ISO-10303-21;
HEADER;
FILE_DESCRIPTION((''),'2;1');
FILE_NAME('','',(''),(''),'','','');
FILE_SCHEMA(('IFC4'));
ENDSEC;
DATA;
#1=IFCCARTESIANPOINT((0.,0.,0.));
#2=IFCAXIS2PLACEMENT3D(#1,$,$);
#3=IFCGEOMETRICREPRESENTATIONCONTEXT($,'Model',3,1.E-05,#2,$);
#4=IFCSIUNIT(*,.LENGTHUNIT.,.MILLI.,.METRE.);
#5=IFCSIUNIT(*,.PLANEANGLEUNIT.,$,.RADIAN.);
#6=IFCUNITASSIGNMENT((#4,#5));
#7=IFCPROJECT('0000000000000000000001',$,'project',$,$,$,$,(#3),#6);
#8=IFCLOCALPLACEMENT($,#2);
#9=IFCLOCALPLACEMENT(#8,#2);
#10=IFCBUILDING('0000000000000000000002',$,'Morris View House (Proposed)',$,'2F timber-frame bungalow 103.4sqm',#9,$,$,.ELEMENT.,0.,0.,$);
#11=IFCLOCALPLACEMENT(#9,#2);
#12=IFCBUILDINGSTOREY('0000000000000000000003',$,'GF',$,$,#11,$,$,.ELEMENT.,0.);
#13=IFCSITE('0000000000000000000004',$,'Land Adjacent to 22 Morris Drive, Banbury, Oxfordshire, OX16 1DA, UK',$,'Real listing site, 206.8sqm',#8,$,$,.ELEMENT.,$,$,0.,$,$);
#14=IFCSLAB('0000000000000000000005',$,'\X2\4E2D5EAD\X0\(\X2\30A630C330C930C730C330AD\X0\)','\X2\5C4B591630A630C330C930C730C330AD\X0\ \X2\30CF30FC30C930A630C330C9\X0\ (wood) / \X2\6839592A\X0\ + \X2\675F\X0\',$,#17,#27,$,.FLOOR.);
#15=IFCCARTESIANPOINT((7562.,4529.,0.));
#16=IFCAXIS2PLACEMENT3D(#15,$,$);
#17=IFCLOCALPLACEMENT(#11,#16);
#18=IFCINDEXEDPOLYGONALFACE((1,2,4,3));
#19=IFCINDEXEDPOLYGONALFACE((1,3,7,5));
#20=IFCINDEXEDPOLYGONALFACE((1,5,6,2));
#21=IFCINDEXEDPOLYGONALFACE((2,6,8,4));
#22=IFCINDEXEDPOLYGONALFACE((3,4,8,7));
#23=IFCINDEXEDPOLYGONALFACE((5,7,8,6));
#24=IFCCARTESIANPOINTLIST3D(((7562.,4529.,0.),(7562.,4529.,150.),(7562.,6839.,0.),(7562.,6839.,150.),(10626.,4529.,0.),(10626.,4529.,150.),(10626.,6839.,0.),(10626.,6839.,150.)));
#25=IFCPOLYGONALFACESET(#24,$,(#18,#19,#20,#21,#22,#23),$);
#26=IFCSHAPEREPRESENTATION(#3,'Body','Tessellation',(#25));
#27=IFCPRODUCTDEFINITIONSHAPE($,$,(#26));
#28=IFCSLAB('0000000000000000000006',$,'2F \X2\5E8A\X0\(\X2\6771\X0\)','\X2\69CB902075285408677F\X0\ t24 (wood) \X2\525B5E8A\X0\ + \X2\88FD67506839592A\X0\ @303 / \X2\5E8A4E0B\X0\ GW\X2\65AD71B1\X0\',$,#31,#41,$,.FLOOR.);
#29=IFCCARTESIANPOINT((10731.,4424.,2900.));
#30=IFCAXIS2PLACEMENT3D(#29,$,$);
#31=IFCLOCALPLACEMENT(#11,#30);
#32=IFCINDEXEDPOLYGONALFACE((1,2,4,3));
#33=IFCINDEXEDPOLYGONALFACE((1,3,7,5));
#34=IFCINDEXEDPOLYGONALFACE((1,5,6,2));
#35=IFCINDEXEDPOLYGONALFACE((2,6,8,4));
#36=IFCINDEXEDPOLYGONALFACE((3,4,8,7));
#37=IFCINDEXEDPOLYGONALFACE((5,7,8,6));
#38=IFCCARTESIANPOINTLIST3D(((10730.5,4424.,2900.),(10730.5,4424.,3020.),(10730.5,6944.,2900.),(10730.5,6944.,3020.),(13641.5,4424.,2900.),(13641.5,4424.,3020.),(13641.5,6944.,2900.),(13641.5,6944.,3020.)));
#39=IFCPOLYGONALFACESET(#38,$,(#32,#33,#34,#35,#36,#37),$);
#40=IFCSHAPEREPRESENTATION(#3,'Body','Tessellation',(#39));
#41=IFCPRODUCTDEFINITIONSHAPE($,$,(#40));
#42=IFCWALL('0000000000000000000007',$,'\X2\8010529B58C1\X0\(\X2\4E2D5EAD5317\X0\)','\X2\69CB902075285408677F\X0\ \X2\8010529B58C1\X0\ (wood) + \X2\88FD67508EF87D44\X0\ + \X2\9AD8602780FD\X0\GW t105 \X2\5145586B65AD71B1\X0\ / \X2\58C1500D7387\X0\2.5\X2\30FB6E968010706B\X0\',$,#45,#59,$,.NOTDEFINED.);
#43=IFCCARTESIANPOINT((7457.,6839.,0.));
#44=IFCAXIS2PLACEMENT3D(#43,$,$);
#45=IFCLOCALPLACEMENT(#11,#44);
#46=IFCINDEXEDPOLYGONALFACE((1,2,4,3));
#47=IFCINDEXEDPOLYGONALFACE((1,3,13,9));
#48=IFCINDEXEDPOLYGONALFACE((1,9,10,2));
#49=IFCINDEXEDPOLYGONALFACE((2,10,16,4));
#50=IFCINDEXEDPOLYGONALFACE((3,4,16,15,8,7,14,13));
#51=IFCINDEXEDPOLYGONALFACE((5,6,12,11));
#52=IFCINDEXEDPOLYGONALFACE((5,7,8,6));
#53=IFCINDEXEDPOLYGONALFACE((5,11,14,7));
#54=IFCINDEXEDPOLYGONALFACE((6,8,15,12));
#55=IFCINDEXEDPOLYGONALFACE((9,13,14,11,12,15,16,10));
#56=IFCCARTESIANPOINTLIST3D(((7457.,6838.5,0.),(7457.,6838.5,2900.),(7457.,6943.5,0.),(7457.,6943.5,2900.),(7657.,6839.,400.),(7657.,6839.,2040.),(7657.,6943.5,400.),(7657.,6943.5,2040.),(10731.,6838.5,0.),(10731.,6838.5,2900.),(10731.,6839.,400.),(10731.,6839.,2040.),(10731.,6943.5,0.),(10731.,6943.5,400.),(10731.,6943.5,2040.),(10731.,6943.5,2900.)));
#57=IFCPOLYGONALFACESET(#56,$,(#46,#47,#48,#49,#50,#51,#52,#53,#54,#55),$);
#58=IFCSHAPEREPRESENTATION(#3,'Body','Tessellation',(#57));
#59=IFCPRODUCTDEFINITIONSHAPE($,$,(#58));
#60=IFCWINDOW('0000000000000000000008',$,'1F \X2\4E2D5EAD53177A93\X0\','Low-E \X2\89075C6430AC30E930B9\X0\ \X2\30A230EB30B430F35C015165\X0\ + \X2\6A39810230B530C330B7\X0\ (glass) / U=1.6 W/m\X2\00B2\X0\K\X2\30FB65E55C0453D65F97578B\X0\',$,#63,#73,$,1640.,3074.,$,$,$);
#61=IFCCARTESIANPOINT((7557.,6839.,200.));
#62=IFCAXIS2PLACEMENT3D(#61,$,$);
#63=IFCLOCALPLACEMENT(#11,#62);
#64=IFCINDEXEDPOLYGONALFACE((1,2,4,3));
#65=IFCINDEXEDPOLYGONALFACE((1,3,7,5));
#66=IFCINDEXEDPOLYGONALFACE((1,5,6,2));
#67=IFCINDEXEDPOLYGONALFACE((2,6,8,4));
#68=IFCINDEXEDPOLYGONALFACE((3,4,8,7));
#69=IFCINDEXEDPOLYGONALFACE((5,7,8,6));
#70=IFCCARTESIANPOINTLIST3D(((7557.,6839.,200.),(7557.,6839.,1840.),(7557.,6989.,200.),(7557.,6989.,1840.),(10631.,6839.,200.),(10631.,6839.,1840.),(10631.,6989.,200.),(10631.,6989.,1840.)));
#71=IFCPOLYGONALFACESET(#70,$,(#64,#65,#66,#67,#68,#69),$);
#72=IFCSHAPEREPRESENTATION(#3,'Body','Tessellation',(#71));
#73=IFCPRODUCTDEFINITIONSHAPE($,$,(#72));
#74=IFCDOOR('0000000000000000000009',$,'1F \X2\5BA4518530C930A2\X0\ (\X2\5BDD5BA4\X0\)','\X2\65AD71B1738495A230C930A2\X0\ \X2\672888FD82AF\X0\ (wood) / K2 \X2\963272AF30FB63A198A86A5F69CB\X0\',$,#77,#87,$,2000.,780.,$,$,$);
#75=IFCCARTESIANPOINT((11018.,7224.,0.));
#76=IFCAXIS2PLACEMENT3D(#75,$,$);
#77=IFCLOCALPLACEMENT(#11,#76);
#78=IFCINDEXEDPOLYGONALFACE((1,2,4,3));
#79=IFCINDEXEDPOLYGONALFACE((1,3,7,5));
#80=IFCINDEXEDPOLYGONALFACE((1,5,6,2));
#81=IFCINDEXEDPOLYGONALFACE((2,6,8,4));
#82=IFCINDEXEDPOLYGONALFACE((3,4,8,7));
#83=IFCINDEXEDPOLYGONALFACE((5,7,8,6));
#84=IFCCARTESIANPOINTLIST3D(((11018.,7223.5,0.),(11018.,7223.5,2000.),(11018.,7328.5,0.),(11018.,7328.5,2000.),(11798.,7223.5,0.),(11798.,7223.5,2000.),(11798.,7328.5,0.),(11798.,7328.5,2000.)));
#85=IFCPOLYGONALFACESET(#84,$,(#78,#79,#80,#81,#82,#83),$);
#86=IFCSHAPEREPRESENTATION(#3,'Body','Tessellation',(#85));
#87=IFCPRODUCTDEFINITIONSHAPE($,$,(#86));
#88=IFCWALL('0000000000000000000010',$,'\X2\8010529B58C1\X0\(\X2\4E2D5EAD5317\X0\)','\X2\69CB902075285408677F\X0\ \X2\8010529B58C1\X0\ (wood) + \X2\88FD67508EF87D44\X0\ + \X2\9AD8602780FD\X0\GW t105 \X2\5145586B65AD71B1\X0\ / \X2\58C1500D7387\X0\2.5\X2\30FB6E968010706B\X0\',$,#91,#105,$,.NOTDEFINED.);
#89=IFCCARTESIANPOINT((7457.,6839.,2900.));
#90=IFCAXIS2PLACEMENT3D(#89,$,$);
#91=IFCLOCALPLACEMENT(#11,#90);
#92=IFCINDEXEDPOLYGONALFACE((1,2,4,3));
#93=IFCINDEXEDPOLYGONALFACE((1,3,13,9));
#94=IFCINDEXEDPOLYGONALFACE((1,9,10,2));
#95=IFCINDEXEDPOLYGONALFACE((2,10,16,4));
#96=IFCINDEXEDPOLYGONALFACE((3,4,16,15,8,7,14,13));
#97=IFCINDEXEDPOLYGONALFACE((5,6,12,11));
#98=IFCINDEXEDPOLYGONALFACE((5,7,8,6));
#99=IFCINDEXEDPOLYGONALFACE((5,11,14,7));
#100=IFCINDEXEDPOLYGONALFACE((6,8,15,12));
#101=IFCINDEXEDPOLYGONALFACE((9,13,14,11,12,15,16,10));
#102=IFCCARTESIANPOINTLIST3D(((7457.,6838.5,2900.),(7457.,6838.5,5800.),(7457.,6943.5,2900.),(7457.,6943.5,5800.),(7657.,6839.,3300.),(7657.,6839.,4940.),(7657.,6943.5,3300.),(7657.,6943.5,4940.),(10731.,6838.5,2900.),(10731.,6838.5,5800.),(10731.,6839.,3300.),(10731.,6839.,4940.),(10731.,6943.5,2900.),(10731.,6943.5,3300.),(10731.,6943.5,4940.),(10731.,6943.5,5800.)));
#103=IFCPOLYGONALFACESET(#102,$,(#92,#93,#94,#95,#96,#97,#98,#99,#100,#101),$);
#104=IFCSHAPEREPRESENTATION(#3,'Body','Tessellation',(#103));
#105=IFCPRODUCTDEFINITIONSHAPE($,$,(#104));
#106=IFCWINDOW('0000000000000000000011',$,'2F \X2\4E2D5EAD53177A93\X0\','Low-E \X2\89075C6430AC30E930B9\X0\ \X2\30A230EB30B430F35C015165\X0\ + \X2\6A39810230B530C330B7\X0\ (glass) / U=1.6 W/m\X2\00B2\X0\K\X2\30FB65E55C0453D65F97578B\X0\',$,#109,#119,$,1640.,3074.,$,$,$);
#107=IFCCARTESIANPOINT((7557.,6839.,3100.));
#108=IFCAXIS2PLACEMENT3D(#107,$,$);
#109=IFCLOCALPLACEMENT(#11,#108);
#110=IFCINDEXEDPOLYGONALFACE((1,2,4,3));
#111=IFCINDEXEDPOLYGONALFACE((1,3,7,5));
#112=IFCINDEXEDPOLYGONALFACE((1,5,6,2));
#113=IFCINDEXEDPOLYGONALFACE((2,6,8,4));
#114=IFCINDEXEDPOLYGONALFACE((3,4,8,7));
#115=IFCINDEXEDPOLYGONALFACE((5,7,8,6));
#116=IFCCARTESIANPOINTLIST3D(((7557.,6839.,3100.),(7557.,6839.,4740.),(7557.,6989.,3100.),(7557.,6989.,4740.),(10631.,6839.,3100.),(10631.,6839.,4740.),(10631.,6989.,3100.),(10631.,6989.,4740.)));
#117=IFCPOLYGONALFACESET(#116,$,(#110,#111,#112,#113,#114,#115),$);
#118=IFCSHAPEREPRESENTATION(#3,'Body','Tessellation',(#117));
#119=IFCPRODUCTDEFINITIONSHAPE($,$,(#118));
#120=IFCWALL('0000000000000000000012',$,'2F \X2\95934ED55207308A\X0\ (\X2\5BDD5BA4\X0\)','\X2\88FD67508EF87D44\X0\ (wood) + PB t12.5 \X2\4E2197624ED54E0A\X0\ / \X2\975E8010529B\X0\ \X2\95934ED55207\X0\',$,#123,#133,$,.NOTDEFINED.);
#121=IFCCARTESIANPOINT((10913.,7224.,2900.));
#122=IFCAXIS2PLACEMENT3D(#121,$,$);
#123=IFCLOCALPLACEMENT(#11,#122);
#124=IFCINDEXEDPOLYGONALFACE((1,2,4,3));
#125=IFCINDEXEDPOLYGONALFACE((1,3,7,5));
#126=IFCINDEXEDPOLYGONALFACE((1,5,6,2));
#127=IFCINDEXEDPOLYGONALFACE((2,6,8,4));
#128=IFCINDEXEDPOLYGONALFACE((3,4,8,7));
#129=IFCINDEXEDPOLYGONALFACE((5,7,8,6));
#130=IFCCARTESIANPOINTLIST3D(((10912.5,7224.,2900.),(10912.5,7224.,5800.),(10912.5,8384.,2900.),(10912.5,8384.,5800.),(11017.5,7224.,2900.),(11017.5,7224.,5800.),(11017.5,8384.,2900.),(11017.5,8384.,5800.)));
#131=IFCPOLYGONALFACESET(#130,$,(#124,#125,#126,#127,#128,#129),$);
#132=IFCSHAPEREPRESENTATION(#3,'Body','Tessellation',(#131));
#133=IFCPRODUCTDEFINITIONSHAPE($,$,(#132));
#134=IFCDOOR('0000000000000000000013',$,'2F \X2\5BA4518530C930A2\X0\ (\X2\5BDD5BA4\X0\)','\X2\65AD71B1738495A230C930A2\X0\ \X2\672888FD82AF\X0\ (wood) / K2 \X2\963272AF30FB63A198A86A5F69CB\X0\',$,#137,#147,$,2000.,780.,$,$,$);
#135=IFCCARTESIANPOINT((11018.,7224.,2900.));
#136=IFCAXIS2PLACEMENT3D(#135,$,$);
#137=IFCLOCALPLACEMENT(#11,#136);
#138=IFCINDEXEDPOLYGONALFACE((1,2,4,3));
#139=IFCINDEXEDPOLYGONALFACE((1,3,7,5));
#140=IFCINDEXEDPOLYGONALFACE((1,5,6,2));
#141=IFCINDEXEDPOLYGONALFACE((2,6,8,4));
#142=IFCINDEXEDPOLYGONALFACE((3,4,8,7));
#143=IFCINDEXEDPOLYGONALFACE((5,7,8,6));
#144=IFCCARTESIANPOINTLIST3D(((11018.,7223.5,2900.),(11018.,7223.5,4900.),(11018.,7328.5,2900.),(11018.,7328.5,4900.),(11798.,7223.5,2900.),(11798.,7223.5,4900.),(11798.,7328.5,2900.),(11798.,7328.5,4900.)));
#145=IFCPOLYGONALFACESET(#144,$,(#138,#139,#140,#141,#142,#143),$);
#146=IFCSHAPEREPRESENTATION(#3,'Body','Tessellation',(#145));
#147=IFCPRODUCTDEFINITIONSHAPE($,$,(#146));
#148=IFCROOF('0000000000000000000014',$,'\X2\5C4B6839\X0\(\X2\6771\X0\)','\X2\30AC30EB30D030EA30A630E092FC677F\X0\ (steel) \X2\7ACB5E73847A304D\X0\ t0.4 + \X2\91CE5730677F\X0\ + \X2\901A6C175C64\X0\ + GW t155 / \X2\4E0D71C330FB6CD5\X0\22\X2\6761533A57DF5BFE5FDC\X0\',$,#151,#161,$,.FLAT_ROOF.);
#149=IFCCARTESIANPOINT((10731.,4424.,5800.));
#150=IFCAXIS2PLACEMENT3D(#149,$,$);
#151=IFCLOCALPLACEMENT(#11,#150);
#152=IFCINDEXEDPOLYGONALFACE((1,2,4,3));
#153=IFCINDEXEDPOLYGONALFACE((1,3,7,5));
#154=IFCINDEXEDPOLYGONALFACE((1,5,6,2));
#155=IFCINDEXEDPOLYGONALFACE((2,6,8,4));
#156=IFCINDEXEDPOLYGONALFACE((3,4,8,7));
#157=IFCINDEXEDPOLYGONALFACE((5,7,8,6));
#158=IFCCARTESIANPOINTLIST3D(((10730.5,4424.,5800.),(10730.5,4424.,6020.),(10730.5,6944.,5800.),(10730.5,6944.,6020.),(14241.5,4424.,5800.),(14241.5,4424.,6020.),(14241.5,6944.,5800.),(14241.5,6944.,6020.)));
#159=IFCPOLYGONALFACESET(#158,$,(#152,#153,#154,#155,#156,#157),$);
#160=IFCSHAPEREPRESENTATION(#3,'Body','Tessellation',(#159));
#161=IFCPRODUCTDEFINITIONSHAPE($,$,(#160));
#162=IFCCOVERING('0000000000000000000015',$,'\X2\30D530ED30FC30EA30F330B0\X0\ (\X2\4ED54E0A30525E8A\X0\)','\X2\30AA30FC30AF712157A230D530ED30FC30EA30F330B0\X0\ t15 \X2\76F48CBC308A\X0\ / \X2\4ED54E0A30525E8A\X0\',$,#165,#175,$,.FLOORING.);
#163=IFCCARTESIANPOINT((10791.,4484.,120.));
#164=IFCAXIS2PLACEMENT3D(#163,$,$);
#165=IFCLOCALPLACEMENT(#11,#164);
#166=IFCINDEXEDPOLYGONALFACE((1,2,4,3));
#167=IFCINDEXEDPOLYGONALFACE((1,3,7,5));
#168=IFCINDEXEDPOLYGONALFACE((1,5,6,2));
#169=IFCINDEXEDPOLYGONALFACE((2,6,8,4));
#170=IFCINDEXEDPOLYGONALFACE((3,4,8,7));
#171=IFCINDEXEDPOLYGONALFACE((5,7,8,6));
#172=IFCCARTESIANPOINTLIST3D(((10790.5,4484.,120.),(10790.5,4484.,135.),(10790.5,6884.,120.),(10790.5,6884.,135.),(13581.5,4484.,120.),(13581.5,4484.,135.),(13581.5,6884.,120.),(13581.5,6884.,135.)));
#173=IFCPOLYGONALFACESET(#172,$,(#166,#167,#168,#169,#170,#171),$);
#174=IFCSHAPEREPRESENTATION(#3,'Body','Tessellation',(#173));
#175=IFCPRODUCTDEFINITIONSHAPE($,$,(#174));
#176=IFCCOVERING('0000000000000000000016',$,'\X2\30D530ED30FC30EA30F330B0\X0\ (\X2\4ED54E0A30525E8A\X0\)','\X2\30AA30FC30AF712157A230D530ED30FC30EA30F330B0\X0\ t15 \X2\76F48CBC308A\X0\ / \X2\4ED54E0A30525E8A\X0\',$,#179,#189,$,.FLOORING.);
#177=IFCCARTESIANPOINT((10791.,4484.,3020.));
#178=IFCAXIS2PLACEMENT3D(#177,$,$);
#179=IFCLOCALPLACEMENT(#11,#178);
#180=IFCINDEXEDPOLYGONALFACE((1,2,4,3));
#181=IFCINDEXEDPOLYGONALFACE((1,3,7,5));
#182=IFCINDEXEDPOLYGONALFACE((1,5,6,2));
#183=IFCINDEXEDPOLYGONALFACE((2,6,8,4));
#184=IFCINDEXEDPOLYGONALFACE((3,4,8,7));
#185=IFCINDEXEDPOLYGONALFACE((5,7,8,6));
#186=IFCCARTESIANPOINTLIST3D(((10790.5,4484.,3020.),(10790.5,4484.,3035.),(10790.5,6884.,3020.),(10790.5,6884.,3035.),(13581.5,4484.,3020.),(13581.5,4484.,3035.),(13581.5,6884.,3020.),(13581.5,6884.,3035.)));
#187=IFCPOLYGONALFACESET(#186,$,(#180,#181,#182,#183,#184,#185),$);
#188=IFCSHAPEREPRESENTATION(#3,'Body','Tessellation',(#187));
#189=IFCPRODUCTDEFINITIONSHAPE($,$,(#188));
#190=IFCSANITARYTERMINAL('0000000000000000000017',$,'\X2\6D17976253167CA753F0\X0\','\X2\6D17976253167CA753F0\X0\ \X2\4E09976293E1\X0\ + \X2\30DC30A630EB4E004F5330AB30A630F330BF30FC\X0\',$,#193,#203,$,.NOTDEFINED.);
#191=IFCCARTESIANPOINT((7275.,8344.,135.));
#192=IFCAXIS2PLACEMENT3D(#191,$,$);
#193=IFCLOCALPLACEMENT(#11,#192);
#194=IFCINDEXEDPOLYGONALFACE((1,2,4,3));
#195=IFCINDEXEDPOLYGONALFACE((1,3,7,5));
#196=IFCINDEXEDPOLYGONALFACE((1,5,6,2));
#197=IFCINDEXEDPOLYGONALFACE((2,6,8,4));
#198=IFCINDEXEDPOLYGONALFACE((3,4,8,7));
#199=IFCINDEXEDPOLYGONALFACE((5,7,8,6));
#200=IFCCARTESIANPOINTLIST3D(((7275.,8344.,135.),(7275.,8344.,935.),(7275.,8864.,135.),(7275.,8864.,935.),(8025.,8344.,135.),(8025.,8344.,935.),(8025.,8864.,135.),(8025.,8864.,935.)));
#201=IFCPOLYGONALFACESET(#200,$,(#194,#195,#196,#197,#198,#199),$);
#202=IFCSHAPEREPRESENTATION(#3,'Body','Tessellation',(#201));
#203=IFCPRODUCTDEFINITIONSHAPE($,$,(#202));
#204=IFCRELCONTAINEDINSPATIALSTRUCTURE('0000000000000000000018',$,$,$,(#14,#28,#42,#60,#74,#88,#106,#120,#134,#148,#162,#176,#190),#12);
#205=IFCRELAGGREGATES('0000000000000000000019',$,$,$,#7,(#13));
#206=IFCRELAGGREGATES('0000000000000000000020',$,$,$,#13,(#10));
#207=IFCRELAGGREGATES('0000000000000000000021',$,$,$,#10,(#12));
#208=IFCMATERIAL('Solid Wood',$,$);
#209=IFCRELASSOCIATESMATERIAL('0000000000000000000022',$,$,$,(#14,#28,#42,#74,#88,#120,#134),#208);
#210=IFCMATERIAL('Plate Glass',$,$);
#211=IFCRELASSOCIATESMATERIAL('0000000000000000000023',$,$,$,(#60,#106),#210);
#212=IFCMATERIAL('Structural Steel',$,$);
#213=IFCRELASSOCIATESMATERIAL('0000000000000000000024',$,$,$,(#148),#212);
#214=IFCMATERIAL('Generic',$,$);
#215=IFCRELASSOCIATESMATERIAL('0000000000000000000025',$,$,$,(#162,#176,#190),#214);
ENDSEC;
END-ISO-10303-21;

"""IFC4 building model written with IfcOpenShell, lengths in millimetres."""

from ifc_helpers import new_model, si_unit, frame, frame_2d, origin, place, context, project, spatial, rectangle, extrude, material, element, fill, save


model = new_model("IFC4")

# Units and contexts
model_context = context("Model", 3, precision=1e-05, world=origin())
ifc_project = project(units=[si_unit("LENGTHUNIT", "METRE", prefix="MILLI"), si_unit("PLANEANGLEUNIT", "RADIAN")], contexts=[model_context])

# Site, building, storey
site_placement = place(None, origin())
site = spatial("IfcSite", under=ifc_project, at=site_placement, Name="Land Adjacent to 22 Morris Drive, Banbury, Oxfordshire, OX16 1DA, UK", ObjectType="Real listing site, 206.8sqm", CompositionType="ELEMENT", RefElevation=0.0)
building_placement = place(site_placement, origin())
building = spatial("IfcBuilding", under=site, at=building_placement, Name="Morris View House (Proposed)", ObjectType="2F timber-frame bungalow 103.4sqm", CompositionType="ELEMENT", ElevationOfRefHeight=0.0, ElevationOfTerrain=0.0)
storey_placement = place(building_placement, origin())
storey = spatial("IfcBuildingStorey", under=building, at=storey_placement, Name="GF", CompositionType="ELEMENT", Elevation=0.0)

# Slabs
ifc_material_1 = material(Name="Solid Wood")
slab_1_placement = place(storey_placement, frame((7562.0, 4529.0, 0.0)))
element("IfcSlab", 1, at=slab_1_placement, inside=storey, material=ifc_material_1, Name="中庭(ウッドデッキ)", Description="屋外ウッドデッキ ハードウッド (wood) / 根太 + 束", PredefinedType="FLOOR", context=model_context, shape_type="SweptSolid", body=[
    extrude(rectangle(XDim=3064.0, YDim=2310.0, at=frame_2d((1532.0, 1155.0))), frame((7562.0, 4529.0, 0.0)), (0.0, 0.0, 1.0), 150.0),
])
slab_2_placement = place(storey_placement, frame((10731.0, 4424.0, 2900.0)))
element("IfcSlab", 2, at=slab_2_placement, inside=storey, material=ifc_material_1, Name="2F 床(東)", Description="構造用合板 t24 (wood) 剛床 + 製材根太 @303 / 床下 GW断熱", PredefinedType="FLOOR", context=model_context, shape_type="SweptSolid", body=[
    extrude(rectangle(XDim=2911.0, YDim=2520.0, at=frame_2d((1455.0, 1260.0))), frame((10731.0, 4424.0, 2900.0)), (0.0, 0.0, 1.0), 120.0),
])

# Wall, opening, window
wall_1_placement = place(storey_placement, frame((7457.0, 6839.0, 0.0)))
wall_1 = element("IfcWall", 3, at=wall_1_placement, inside=storey, material=ifc_material_1, Name="耐力壁(中庭北)", Description="構造用合板 耐力壁 (wood) + 製材軸組 + 高性能GW t105 充填断熱 / 壁倍率2.5・準耐火", PredefinedType="NOTDEFINED", context=model_context, shape_type="SweptSolid", body=[
    extrude(rectangle(XDim=3274.0, YDim=105.0, at=frame_2d((1637.0, 52.0))), frame((7457.0, 6839.0, 0.0)), (0.0, 0.0, 1.0), 2900.0),
])
opening_1_placement = place(storey_placement, frame((7557.0, 6839.0, 200.0)))
opening_1 = element("IfcOpeningElement", 4, at=opening_1_placement, cuts=wall_1, PredefinedType="NOTDEFINED", context=model_context, shape_type="SweptSolid", body=[
    extrude(rectangle(XDim=3074.0, YDim=150.0, at=frame_2d((1537.0, 75.0))), frame((7557.0, 6839.0, 200.0)), (0.0, 0.0, 1.0), 1640.0),
])
ifc_material_2 = material(Name="Plate Glass")
window_1_placement = place(storey_placement, frame((7557.0, 6839.0, 200.0)))
window_1 = element("IfcWindow", 5, at=window_1_placement, inside=storey, material=ifc_material_2, Name="1F 中庭北窓", Description="Low-E 複層ガラス アルゴン封入 + 樹脂サッシ (glass) / U=1.6 W/m²K・日射取得型", OverallHeight=1640.0, OverallWidth=3074.0, context=model_context, shape_type="SweptSolid", body=[
    extrude(rectangle(XDim=3074.0, YDim=150.0, at=frame_2d((1537.0, 75.0))), frame((7557.0, 6839.0, 200.0)), (0.0, 0.0, 1.0), 1640.0),
])
fill(opening_1, window_1)

# Door
door_1_placement = place(storey_placement, frame((11018.0, 7224.0, 0.0)))
element("IfcDoor", 6, at=door_1_placement, inside=storey, material=ifc_material_1, Name="1F 室内ドア (寝室)", Description="断熱玄関ドア 木製芯 (wood) / K2 防犯・採風機構", OverallHeight=2000.0, OverallWidth=780.0, context=model_context, shape_type="SweptSolid", body=[
    extrude(rectangle(XDim=780.0, YDim=105.0, at=frame_2d((390.0, 52.0))), frame((11018.0, 7224.0, 0.0)), (0.0, 0.0, 1.0), 2000.0),
])

# Wall, opening, window
wall_2_placement = place(storey_placement, frame((7457.0, 6839.0, 2900.0)))
wall_2 = element("IfcWall", 7, at=wall_2_placement, inside=storey, material=ifc_material_1, Name="耐力壁(中庭北)", Description="構造用合板 耐力壁 (wood) + 製材軸組 + 高性能GW t105 充填断熱 / 壁倍率2.5・準耐火", PredefinedType="NOTDEFINED", context=model_context, shape_type="SweptSolid", body=[
    extrude(rectangle(XDim=3274.0, YDim=105.0, at=frame_2d((1637.0, 52.0))), frame((7457.0, 6839.0, 2900.0)), (0.0, 0.0, 1.0), 2900.0),
])
opening_2_placement = place(storey_placement, frame((7557.0, 6839.0, 3100.0)))
opening_2 = element("IfcOpeningElement", 8, at=opening_2_placement, cuts=wall_2, PredefinedType="NOTDEFINED", context=model_context, shape_type="SweptSolid", body=[
    extrude(rectangle(XDim=3074.0, YDim=150.0, at=frame_2d((1537.0, 75.0))), frame((7557.0, 6839.0, 3100.0)), (0.0, 0.0, 1.0), 1640.0),
])
window_2_placement = place(storey_placement, frame((7557.0, 6839.0, 3100.0)))
window_2 = element("IfcWindow", 9, at=window_2_placement, inside=storey, material=ifc_material_2, Name="2F 中庭北窓", Description="Low-E 複層ガラス アルゴン封入 + 樹脂サッシ (glass) / U=1.6 W/m²K・日射取得型", OverallHeight=1640.0, OverallWidth=3074.0, context=model_context, shape_type="SweptSolid", body=[
    extrude(rectangle(XDim=3074.0, YDim=150.0, at=frame_2d((1537.0, 75.0))), frame((7557.0, 6839.0, 3100.0)), (0.0, 0.0, 1.0), 1640.0),
])
fill(opening_2, window_2)

# Wall
wall_3_placement = place(storey_placement, frame((10913.0, 7224.0, 2900.0)))
element("IfcWall", 10, at=wall_3_placement, inside=storey, material=ifc_material_1, Name="2F 間仕切り (寝室)", Description="製材軸組 (wood) + PB t12.5 両面仕上 / 非耐力 間仕切", PredefinedType="NOTDEFINED", context=model_context, shape_type="SweptSolid", body=[
    extrude(rectangle(XDim=105.0, YDim=1160.0, at=frame_2d((52.0, 580.0))), frame((10913.0, 7224.0, 2900.0)), (0.0, 0.0, 1.0), 2900.0),
])

# Door
door_2_placement = place(storey_placement, frame((11018.0, 7224.0, 2900.0)))
element("IfcDoor", 11, at=door_2_placement, inside=storey, material=ifc_material_1, Name="2F 室内ドア (寝室)", Description="断熱玄関ドア 木製芯 (wood) / K2 防犯・採風機構", OverallHeight=2000.0, OverallWidth=780.0, context=model_context, shape_type="SweptSolid", body=[
    extrude(rectangle(XDim=780.0, YDim=105.0, at=frame_2d((390.0, 52.0))), frame((11018.0, 7224.0, 2900.0)), (0.0, 0.0, 1.0), 2000.0),
])

# Roof
ifc_material_3 = material(Name="Structural Steel")
for number, where, name in (
    (12, (10731.0, 4424.0, 5800.0), "屋根(東)"),
):
    element("IfcRoof", number, at=place(storey_placement, frame(where)), inside=storey, material=ifc_material_3, Name=name, Description="ガルバリウム鋼板 (steel) 立平葺き t0.4 + 野地板 + 通気層 + GW t155 / 不燃・法22条区域対応", PredefinedType="FLAT_ROOF", context=model_context, shape_type="SweptSolid", body=[
        extrude(rectangle(XDim=3511.0, YDim=2520.0, at=frame_2d((1755.0, 1260.0))), frame((10731.0, 4424.0, 5800.0)), (0.0, 0.0, 1.0), 220.0),
    ])

# Coverings
ifc_material_4 = material(Name="Generic")
covering_1_placement = place(storey_placement, frame((10791.0, 4484.0, 120.0)))
element("IfcCovering", 13, at=covering_1_placement, inside=storey, material=ifc_material_4, Name="フローリング (仕上げ床)", Description="オーク無垢フローリング t15 直貼り / 仕上げ床", PredefinedType="FLOORING", context=model_context, shape_type="SweptSolid", body=[
    extrude(rectangle(XDim=2791.0, YDim=2400.0, at=frame_2d((1395.0, 1200.0))), frame((10791.0, 4484.0, 120.0)), (0.0, 0.0, 1.0), 15.0),
])
covering_2_placement = place(storey_placement, frame((10791.0, 4484.0, 3020.0)))
element("IfcCovering", 14, at=covering_2_placement, inside=storey, material=ifc_material_4, Name="フローリング (仕上げ床)", Description="オーク無垢フローリング t15 直貼り / 仕上げ床", PredefinedType="FLOORING", context=model_context, shape_type="SweptSolid", body=[
    extrude(rectangle(XDim=2791.0, YDim=2400.0, at=frame_2d((1395.0, 1200.0))), frame((10791.0, 4484.0, 3020.0)), (0.0, 0.0, 1.0), 15.0),
])

# Sanitary terminal
sanitary_terminal_1_placement = place(storey_placement, frame((7275.0, 8344.0, 135.0)))
element("IfcSanitaryTerminal", 15, at=sanitary_terminal_1_placement, inside=storey, material=ifc_material_4, Name="洗面化粧台", Description="洗面化粧台 三面鏡 + ボウル一体カウンター", PredefinedType="NOTDEFINED", context=model_context, shape_type="SweptSolid", body=[
    extrude(rectangle(XDim=750.0, YDim=520.0, at=frame_2d((375.0, 260.0))), frame((7275.0, 8344.0, 135.0)), (0.0, 0.0, 1.0), 800.0),
])

save(model, "model.ifc")
